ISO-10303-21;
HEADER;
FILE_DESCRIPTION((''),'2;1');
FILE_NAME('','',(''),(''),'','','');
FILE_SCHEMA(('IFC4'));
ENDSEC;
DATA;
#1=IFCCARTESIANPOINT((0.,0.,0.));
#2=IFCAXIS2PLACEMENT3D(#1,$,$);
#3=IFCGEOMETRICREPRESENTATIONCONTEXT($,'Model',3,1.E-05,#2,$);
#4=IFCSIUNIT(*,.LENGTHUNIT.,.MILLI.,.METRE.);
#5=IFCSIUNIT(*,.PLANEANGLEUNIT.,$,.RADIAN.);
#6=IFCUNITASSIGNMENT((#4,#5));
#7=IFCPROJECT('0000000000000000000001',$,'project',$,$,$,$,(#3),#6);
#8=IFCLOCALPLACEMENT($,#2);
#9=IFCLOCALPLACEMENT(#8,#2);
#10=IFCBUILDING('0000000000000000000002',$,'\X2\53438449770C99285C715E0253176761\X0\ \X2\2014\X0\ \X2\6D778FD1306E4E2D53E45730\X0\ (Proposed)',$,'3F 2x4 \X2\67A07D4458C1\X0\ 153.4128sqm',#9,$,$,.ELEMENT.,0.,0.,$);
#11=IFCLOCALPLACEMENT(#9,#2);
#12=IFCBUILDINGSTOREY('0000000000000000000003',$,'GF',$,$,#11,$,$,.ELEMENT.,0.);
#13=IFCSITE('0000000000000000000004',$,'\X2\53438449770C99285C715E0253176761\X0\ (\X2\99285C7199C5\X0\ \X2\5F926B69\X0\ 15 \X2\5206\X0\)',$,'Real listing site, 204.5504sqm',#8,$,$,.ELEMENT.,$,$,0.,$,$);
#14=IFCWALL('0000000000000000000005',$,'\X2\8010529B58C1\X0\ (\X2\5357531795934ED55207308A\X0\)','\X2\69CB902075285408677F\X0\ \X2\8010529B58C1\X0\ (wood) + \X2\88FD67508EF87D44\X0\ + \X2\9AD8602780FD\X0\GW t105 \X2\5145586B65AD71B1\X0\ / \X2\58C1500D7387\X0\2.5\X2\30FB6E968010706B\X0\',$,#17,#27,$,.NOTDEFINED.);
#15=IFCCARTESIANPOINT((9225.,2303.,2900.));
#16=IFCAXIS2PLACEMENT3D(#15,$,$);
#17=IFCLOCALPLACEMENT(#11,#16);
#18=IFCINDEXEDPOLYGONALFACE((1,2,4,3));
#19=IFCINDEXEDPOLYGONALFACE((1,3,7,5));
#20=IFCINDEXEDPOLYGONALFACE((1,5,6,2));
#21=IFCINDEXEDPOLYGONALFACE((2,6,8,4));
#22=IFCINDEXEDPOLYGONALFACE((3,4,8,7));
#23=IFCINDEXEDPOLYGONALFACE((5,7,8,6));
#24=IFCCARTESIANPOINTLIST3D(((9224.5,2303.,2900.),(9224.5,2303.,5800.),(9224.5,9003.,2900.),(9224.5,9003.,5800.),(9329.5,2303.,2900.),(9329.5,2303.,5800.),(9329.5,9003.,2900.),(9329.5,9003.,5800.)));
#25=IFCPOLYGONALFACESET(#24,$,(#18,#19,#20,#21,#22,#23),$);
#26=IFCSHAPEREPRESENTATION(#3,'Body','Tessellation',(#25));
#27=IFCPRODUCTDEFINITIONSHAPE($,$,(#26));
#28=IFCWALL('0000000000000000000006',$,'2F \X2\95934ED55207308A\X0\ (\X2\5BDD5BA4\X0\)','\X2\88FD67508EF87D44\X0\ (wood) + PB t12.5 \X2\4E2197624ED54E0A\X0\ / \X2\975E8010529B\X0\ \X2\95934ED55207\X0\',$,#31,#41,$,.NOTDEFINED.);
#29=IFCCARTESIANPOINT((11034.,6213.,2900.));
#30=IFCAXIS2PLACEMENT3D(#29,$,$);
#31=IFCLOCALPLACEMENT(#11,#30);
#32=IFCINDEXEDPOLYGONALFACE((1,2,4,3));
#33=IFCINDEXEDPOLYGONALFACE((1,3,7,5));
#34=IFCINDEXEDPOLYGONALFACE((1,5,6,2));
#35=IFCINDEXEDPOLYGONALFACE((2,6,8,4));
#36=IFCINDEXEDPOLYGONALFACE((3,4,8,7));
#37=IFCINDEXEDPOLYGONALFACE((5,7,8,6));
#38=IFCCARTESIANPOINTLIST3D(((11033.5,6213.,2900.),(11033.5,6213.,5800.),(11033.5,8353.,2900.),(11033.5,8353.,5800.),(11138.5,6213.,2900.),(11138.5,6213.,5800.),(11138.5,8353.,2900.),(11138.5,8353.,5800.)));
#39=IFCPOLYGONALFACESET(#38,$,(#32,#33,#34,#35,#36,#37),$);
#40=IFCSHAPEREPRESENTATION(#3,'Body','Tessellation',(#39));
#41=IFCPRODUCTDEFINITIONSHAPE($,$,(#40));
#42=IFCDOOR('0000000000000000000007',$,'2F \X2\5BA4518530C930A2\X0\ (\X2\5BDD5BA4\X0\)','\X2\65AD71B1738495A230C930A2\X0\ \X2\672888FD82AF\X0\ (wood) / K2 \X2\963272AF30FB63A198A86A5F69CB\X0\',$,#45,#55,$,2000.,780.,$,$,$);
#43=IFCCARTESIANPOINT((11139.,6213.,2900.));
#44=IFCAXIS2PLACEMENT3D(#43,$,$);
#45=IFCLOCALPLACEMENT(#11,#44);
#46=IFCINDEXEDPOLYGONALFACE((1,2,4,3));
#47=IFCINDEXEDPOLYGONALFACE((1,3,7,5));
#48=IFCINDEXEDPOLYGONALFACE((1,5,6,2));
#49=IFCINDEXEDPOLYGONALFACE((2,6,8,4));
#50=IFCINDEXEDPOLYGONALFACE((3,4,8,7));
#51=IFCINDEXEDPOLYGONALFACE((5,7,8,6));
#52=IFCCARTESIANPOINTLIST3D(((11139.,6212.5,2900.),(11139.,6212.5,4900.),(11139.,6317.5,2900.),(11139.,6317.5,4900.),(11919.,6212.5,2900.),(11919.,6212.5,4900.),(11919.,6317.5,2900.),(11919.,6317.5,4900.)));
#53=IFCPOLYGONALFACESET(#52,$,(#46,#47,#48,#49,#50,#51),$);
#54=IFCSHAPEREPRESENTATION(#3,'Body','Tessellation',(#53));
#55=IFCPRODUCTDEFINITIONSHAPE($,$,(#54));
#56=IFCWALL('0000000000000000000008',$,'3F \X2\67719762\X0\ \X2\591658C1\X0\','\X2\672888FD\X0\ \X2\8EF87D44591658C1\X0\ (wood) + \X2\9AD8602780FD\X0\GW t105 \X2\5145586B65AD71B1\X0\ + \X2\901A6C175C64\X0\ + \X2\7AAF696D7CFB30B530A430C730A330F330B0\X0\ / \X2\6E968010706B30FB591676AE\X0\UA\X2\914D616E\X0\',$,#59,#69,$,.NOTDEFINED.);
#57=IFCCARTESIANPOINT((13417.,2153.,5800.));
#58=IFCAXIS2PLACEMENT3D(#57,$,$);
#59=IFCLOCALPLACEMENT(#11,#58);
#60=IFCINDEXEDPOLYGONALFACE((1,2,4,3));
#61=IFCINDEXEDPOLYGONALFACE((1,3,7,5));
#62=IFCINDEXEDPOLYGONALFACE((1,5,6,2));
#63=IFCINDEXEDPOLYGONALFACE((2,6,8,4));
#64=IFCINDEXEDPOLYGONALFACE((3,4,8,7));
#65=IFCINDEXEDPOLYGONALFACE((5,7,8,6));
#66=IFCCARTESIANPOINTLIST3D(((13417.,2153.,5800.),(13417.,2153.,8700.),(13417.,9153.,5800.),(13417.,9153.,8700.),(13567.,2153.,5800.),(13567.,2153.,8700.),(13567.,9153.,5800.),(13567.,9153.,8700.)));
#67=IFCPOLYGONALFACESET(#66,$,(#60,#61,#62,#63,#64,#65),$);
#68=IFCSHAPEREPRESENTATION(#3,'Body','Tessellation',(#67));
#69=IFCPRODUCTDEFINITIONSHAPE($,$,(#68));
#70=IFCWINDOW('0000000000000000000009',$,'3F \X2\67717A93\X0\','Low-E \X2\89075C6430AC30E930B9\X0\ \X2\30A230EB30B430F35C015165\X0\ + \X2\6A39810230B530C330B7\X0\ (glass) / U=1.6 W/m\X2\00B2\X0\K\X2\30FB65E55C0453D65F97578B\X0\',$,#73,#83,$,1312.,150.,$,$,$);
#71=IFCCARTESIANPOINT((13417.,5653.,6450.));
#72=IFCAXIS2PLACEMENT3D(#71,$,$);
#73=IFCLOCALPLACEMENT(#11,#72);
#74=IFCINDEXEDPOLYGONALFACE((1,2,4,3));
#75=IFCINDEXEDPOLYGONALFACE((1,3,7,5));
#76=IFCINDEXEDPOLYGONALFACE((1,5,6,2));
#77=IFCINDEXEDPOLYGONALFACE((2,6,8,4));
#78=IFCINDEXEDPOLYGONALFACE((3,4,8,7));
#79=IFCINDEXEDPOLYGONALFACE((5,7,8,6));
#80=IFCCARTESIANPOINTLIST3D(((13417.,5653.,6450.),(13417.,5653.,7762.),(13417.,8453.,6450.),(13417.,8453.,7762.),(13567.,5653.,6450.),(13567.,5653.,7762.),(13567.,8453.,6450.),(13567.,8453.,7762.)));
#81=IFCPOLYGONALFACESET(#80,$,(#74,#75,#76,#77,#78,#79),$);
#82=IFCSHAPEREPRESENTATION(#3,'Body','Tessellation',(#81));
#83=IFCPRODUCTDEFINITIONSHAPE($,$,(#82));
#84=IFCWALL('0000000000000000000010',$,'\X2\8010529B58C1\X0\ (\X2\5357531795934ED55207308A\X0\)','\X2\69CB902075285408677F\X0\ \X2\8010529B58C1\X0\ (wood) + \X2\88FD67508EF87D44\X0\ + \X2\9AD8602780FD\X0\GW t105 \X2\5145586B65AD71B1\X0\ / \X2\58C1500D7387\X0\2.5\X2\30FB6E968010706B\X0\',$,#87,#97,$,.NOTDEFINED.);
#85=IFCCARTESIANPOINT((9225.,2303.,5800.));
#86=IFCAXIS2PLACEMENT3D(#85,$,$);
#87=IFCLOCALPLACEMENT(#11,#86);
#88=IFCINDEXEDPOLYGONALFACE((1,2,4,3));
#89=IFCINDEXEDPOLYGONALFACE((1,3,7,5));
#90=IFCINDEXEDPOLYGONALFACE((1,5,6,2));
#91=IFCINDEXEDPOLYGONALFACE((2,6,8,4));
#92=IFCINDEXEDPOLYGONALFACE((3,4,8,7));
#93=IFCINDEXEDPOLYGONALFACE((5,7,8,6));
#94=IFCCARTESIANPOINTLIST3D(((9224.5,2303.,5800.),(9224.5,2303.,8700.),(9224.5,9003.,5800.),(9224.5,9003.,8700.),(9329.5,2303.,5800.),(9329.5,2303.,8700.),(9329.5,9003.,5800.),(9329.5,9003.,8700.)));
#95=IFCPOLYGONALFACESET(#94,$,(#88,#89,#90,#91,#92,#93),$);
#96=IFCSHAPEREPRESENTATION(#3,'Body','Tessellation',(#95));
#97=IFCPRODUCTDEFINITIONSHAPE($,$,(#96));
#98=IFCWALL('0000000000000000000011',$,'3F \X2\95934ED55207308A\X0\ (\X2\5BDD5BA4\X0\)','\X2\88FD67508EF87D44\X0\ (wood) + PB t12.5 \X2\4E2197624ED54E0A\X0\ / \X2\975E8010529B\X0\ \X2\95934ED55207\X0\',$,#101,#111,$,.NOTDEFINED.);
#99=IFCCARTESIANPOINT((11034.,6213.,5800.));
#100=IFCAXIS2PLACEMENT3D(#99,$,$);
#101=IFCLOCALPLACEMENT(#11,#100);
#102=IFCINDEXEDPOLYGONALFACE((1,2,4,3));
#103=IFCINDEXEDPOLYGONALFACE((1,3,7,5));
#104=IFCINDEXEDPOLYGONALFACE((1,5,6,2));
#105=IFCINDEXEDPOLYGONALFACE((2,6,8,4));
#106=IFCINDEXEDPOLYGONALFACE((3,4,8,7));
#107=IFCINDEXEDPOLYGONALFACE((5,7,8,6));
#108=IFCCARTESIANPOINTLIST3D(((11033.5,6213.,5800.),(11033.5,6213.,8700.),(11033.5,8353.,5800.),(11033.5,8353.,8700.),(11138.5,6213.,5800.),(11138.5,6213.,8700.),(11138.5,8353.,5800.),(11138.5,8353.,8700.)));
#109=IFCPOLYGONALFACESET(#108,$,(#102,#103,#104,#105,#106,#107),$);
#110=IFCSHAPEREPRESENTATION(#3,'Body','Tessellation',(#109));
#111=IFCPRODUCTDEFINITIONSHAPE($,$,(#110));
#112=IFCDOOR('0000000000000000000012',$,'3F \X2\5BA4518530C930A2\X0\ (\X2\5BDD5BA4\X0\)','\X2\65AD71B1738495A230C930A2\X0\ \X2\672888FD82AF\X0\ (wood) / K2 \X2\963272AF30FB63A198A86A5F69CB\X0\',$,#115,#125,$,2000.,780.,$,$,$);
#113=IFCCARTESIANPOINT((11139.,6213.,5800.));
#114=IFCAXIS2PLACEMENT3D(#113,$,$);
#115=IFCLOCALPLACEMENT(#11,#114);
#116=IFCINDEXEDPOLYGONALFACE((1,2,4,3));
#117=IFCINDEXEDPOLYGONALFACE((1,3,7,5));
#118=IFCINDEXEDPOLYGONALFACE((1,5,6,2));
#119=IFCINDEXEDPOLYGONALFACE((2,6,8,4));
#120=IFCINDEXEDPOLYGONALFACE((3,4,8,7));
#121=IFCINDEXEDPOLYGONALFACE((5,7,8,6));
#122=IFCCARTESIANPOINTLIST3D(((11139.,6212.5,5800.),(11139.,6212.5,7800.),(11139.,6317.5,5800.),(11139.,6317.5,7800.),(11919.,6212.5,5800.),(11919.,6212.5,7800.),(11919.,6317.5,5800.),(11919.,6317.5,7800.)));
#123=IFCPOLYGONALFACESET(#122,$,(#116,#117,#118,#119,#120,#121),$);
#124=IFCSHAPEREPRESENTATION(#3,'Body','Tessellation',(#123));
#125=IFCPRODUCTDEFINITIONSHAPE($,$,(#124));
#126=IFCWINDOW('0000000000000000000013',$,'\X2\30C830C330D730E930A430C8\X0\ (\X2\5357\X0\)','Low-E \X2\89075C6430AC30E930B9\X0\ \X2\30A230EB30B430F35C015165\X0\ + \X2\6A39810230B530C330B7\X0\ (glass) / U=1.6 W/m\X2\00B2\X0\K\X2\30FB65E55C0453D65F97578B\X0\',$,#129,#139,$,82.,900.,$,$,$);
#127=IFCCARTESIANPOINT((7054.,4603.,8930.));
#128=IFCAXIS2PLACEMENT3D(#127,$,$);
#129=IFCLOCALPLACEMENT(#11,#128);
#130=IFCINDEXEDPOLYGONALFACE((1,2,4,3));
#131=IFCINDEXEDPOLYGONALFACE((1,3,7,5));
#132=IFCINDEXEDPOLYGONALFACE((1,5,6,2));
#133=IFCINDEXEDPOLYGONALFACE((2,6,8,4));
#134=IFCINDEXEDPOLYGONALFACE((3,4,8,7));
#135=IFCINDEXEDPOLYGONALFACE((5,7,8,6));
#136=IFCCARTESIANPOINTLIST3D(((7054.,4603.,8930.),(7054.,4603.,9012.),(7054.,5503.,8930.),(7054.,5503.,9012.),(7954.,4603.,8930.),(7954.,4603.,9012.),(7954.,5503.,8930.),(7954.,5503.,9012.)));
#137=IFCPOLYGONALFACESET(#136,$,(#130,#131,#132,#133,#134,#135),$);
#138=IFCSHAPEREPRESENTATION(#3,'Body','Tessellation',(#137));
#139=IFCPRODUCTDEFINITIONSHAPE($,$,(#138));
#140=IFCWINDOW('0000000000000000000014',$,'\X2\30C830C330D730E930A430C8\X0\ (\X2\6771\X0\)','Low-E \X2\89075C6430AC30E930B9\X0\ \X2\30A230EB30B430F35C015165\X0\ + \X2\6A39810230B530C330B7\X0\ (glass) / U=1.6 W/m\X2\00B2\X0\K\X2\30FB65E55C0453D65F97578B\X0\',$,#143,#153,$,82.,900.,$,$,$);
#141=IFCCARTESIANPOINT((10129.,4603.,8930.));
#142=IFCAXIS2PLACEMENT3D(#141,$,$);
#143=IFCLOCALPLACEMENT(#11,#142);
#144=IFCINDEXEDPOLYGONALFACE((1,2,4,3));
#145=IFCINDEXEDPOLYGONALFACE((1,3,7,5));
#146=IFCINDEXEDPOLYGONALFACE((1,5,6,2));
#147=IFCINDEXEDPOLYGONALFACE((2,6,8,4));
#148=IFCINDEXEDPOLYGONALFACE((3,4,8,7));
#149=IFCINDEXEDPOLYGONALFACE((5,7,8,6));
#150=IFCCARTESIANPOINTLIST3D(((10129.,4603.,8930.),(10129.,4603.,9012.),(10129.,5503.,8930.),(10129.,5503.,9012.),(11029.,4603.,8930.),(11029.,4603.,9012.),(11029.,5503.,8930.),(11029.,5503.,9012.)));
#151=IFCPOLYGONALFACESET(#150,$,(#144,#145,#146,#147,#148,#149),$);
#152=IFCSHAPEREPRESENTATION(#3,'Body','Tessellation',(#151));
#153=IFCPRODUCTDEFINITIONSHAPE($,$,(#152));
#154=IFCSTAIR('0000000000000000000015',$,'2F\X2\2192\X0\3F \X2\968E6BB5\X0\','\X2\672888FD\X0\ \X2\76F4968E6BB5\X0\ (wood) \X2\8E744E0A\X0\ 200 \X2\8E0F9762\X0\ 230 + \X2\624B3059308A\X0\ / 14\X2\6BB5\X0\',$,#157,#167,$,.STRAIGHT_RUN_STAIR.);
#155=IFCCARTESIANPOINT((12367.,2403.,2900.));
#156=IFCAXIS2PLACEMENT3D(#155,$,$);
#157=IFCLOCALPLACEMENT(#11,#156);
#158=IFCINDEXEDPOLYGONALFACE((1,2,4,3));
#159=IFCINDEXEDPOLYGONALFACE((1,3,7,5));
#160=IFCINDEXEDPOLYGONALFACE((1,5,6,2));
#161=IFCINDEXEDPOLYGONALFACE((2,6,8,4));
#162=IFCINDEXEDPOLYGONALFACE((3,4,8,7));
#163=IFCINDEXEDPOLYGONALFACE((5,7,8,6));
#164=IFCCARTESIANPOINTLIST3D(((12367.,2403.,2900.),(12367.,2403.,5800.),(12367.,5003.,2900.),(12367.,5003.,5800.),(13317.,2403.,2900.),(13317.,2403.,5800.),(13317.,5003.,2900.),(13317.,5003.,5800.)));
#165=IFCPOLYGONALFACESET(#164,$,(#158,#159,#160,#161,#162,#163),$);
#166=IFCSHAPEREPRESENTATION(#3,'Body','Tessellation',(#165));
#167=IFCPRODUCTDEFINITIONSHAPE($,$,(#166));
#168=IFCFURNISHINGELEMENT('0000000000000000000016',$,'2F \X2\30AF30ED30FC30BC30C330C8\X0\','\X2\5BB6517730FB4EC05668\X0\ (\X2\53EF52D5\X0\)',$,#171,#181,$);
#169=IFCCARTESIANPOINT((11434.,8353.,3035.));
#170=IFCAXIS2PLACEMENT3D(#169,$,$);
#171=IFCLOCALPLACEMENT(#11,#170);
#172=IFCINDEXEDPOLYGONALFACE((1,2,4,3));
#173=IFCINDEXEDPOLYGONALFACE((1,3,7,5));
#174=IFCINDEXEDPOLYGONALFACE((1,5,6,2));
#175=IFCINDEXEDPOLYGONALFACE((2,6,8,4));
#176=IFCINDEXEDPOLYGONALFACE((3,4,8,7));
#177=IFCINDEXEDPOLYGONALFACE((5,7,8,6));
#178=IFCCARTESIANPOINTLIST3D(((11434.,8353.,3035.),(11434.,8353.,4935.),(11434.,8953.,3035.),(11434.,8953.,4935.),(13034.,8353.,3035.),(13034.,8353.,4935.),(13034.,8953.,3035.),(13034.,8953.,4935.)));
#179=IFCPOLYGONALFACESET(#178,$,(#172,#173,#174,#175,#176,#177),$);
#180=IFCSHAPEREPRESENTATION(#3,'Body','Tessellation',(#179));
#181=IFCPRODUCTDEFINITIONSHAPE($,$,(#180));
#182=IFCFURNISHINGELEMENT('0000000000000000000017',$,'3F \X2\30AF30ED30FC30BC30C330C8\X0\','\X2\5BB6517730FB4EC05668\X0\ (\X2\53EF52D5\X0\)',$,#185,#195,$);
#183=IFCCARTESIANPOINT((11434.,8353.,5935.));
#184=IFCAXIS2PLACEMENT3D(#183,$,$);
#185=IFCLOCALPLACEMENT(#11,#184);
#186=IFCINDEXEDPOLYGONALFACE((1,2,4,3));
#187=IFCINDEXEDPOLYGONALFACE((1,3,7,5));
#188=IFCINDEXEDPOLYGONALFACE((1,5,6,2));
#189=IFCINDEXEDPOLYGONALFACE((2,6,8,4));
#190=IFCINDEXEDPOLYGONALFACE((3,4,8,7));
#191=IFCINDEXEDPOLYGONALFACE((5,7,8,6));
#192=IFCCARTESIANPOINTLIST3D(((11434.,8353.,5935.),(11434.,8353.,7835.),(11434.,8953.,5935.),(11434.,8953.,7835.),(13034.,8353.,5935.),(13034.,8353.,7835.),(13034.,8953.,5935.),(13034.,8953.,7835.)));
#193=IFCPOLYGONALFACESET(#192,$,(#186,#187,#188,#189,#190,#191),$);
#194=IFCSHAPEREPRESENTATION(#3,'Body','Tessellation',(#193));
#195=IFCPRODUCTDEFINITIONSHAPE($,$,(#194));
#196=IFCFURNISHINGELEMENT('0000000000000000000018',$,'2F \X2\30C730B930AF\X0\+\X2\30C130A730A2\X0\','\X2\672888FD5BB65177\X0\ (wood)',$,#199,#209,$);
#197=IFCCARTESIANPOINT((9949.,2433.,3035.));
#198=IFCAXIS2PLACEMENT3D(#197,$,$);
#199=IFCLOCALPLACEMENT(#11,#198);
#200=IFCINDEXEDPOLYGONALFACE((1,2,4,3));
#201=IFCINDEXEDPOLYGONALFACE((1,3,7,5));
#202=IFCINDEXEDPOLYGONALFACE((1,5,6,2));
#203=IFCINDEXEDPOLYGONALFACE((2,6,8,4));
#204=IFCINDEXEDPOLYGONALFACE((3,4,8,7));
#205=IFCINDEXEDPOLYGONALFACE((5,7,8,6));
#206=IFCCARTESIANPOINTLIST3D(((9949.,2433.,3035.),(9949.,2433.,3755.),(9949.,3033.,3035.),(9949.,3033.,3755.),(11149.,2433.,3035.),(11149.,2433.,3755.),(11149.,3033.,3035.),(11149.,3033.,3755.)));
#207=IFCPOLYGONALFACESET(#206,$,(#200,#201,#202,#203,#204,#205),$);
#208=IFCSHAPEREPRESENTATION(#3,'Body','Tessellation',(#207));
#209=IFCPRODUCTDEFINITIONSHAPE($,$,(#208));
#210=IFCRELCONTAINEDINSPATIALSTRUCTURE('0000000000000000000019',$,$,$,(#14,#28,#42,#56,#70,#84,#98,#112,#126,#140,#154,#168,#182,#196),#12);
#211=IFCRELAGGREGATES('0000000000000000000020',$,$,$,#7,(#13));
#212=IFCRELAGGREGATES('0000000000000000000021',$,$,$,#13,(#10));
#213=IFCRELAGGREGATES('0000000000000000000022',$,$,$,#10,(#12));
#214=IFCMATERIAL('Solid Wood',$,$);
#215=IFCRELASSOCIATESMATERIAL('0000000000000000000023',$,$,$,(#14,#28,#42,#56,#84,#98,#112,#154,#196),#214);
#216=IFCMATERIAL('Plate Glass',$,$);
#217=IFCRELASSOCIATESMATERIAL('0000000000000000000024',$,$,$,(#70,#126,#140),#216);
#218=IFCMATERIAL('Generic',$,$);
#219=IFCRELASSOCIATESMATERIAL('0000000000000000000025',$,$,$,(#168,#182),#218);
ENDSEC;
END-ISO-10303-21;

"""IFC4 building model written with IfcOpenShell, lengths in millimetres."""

from ifc_helpers import new_model, si_unit, frame, frame_2d, origin, place, context, project, spatial, rectangle, extrude, material, element, fill, save


model = new_model("IFC4")

# Units and contexts
model_context = context("Model", 3, precision=1e-05, world=origin())
ifc_project = project(units=[si_unit("LENGTHUNIT", "METRE", prefix="MILLI"), si_unit("PLANEANGLEUNIT", "RADIAN")], contexts=[model_context])

# Site, building, storey
site_placement = place(None, origin())
site = spatial("IfcSite", under=ifc_project, at=site_placement, Name="千葉県館山市北条 (館山駅 徒歩 15 分)", ObjectType="Real listing site, 204.5504sqm", CompositionType="ELEMENT", RefElevation=0.0)
building_placement = place(site_placement, origin())
building = spatial("IfcBuilding", under=site, at=building_placement, Name="千葉県館山市北条 — 海近の中古地 (Proposed)", ObjectType="3F 2x4 枠組壁 153.4128sqm", CompositionType="ELEMENT", ElevationOfRefHeight=0.0, ElevationOfTerrain=0.0)
storey_placement = place(building_placement, origin())
storey = spatial("IfcBuildingStorey", under=building, at=storey_placement, Name="GF", CompositionType="ELEMENT", Elevation=0.0)

# Walls
ifc_material_1 = material(Name="Solid Wood")
wall_1_placement = place(storey_placement, frame((9225.0, 2303.0, 2900.0)))
element("IfcWall", 1, at=wall_1_placement, inside=storey, material=ifc_material_1, Name="耐力壁 (南北間仕切り)", Description="構造用合板 耐力壁 (wood) + 製材軸組 + 高性能GW t105 充填断熱 / 壁倍率2.5・準耐火", PredefinedType="NOTDEFINED", context=model_context, shape_type="SweptSolid", body=[
    extrude(rectangle(XDim=105.0, YDim=6700.0, at=frame_2d((52.0, 3350.0))), frame((9225.0, 2303.0, 2900.0)), (0.0, 0.0, 1.0), 2900.0),
])
wall_2_placement = place(storey_placement, frame((11034.0, 6213.0, 2900.0)))
element("IfcWall", 2, at=wall_2_placement, inside=storey, material=ifc_material_1, Name="2F 間仕切り (寝室)", Description="製材軸組 (wood) + PB t12.5 両面仕上 / 非耐力 間仕切", PredefinedType="NOTDEFINED", context=model_context, shape_type="SweptSolid", body=[
    extrude(rectangle(XDim=105.0, YDim=2140.0, at=frame_2d((52.0, 1070.0))), frame((11034.0, 6213.0, 2900.0)), (0.0, 0.0, 1.0), 2900.0),
])

# Door
door_1_placement = place(storey_placement, frame((11139.0, 6213.0, 2900.0)))
element("IfcDoor", 3, at=door_1_placement, inside=storey, material=ifc_material_1, Name="2F 室内ドア (寝室)", Description="断熱玄関ドア 木製芯 (wood) / K2 防犯・採風機構", OverallHeight=2000.0, OverallWidth=780.0, context=model_context, shape_type="SweptSolid", body=[
    extrude(rectangle(XDim=780.0, YDim=105.0, at=frame_2d((390.0, 52.0))), frame((11139.0, 6213.0, 2900.0)), (0.0, 0.0, 1.0), 2000.0),
])

# Wall, opening, window
wall_3_placement = place(storey_placement, frame((13417.0, 2153.0, 5800.0)))
wall_3 = element("IfcWall", 4, at=wall_3_placement, inside=storey, material=ifc_material_1, Name="3F 東面 外壁", Description="木製 軸組外壁 (wood) + 高性能GW t105 充填断熱 + 通気層 + 窯業系サイディング / 準耐火・外皮UA配慮", PredefinedType="NOTDEFINED", context=model_context, shape_type="SweptSolid", body=[
    extrude(rectangle(XDim=150.0, YDim=7000.0, at=frame_2d((75.0, 3500.0))), frame((13417.0, 2153.0, 5800.0)), (0.0, 0.0, 1.0), 2900.0),
])
opening_placement = place(storey_placement, frame((13417.0, 5653.0, 6450.0)))
opening = element("IfcOpeningElement", 5, at=opening_placement, cuts=wall_3, PredefinedType="NOTDEFINED", context=model_context, shape_type="SweptSolid", body=[
    extrude(rectangle(XDim=150.0, YDim=2800.0, at=frame_2d((75.0, 1400.0))), frame((13417.0, 5653.0, 6450.0)), (0.0, 0.0, 1.0), 1312.0),
])
ifc_material_2 = material(Name="Plate Glass")
window_1_placement = place(storey_placement, frame((13417.0, 5653.0, 6450.0)))
window_1 = element("IfcWindow", 6, at=window_1_placement, inside=storey, material=ifc_material_2, Name="3F 東窓", Description="Low-E 複層ガラス アルゴン封入 + 樹脂サッシ (glass) / U=1.6 W/m²K・日射取得型", OverallHeight=1312.0, OverallWidth=150.0, context=model_context, shape_type="SweptSolid", body=[
    extrude(rectangle(XDim=150.0, YDim=2800.0, at=frame_2d((75.0, 1400.0))), frame((13417.0, 5653.0, 6450.0)), (0.0, 0.0, 1.0), 1312.0),
])
fill(opening, window_1)

# Walls
wall_4_placement = place(storey_placement, frame((9225.0, 2303.0, 5800.0)))
element("IfcWall", 7, at=wall_4_placement, inside=storey, material=ifc_material_1, Name="耐力壁 (南北間仕切り)", Description="構造用合板 耐力壁 (wood) + 製材軸組 + 高性能GW t105 充填断熱 / 壁倍率2.5・準耐火", PredefinedType="NOTDEFINED", context=model_context, shape_type="SweptSolid", body=[
    extrude(rectangle(XDim=105.0, YDim=6700.0, at=frame_2d((52.0, 3350.0))), frame((9225.0, 2303.0, 5800.0)), (0.0, 0.0, 1.0), 2900.0),
])
wall_5_placement = place(storey_placement, frame((11034.0, 6213.0, 5800.0)))
element("IfcWall", 8, at=wall_5_placement, inside=storey, material=ifc_material_1, Name="3F 間仕切り (寝室)", Description="製材軸組 (wood) + PB t12.5 両面仕上 / 非耐力 間仕切", PredefinedType="NOTDEFINED", context=model_context, shape_type="SweptSolid", body=[
    extrude(rectangle(XDim=105.0, YDim=2140.0, at=frame_2d((52.0, 1070.0))), frame((11034.0, 6213.0, 5800.0)), (0.0, 0.0, 1.0), 2900.0),
])

# Door
door_2_placement = place(storey_placement, frame((11139.0, 6213.0, 5800.0)))
element("IfcDoor", 9, at=door_2_placement, inside=storey, material=ifc_material_1, Name="3F 室内ドア (寝室)", Description="断熱玄関ドア 木製芯 (wood) / K2 防犯・採風機構", OverallHeight=2000.0, OverallWidth=780.0, context=model_context, shape_type="SweptSolid", body=[
    extrude(rectangle(XDim=780.0, YDim=105.0, at=frame_2d((390.0, 52.0))), frame((11139.0, 6213.0, 5800.0)), (0.0, 0.0, 1.0), 2000.0),
])

# Windows
window_2_placement = place(storey_placement, frame((7054.0, 4603.0, 8930.0)))
element("IfcWindow", 10, at=window_2_placement, inside=storey, material=ifc_material_2, Name="トップライト (南)", Description="Low-E 複層ガラス アルゴン封入 + 樹脂サッシ (glass) / U=1.6 W/m²K・日射取得型", OverallHeight=82.0, OverallWidth=900.0, context=model_context, shape_type="SweptSolid", body=[
    extrude(rectangle(XDim=900.0, YDim=900.0, at=frame_2d((450.0, 450.0))), frame((7054.0, 4603.0, 8930.0)), (0.0, 0.0, 1.0), 82.0),
])
window_3_placement = place(storey_placement, frame((10129.0, 4603.0, 8930.0)))
element("IfcWindow", 11, at=window_3_placement, inside=storey, material=ifc_material_2, Name="トップライト (東)", Description="Low-E 複層ガラス アルゴン封入 + 樹脂サッシ (glass) / U=1.6 W/m²K・日射取得型", OverallHeight=82.0, OverallWidth=900.0, context=model_context, shape_type="SweptSolid", body=[
    extrude(rectangle(XDim=900.0, YDim=900.0, at=frame_2d((450.0, 450.0))), frame((10129.0, 4603.0, 8930.0)), (0.0, 0.0, 1.0), 82.0),
])

# Stair
stair_placement = place(storey_placement, frame((12367.0, 2403.0, 2900.0)))
element("IfcStair", 12, at=stair_placement, inside=storey, material=ifc_material_1, Name="2F→3F 階段", Description="木製 直階段 (wood) 蹴上 200 踏面 230 + 手すり / 14段", PredefinedType="STRAIGHT_RUN_STAIR", context=model_context, shape_type="SweptSolid", body=[
    extrude(rectangle(XDim=950.0, YDim=2600.0, at=frame_2d((475.0, 1300.0))), frame((12367.0, 2403.0, 2900.0)), (0.0, 0.0, 1.0), 2900.0),
])

# Furnishing elements
ifc_material_3 = material(Name="Generic")
furnishing_1_placement = place(storey_placement, frame((11434.0, 8353.0, 3035.0)))
element("IfcFurnishingElement", 13, at=furnishing_1_placement, inside=storey, material=ifc_material_3, Name="2F クローゼット", Description="家具・什器 (可動)", context=model_context, shape_type="SweptSolid", body=[
    extrude(rectangle(XDim=1600.0, YDim=600.0, at=frame_2d((800.0, 300.0))), frame((11434.0, 8353.0, 3035.0)), (0.0, 0.0, 1.0), 1900.0),
])
furnishing_2_placement = place(storey_placement, frame((11434.0, 8353.0, 5935.0)))
element("IfcFurnishingElement", 14, at=furnishing_2_placement, inside=storey, material=ifc_material_3, Name="3F クローゼット", Description="家具・什器 (可動)", context=model_context, shape_type="SweptSolid", body=[
    extrude(rectangle(XDim=1600.0, YDim=600.0, at=frame_2d((800.0, 300.0))), frame((11434.0, 8353.0, 5935.0)), (0.0, 0.0, 1.0), 1900.0),
])
furnishing_3_placement = place(storey_placement, frame((9949.0, 2433.0, 3035.0)))
element("IfcFurnishingElement", 15, at=furnishing_3_placement, inside=storey, material=ifc_material_1, Name="2F デスク+チェア", Description="木製家具 (wood)", context=model_context, shape_type="SweptSolid", body=[
    extrude(rectangle(XDim=1200.0, YDim=600.0, at=frame_2d((600.0, 300.0))), frame((9949.0, 2433.0, 3035.0)), (0.0, 0.0, 1.0), 720.0),
])

save(model, "model.ifc")
